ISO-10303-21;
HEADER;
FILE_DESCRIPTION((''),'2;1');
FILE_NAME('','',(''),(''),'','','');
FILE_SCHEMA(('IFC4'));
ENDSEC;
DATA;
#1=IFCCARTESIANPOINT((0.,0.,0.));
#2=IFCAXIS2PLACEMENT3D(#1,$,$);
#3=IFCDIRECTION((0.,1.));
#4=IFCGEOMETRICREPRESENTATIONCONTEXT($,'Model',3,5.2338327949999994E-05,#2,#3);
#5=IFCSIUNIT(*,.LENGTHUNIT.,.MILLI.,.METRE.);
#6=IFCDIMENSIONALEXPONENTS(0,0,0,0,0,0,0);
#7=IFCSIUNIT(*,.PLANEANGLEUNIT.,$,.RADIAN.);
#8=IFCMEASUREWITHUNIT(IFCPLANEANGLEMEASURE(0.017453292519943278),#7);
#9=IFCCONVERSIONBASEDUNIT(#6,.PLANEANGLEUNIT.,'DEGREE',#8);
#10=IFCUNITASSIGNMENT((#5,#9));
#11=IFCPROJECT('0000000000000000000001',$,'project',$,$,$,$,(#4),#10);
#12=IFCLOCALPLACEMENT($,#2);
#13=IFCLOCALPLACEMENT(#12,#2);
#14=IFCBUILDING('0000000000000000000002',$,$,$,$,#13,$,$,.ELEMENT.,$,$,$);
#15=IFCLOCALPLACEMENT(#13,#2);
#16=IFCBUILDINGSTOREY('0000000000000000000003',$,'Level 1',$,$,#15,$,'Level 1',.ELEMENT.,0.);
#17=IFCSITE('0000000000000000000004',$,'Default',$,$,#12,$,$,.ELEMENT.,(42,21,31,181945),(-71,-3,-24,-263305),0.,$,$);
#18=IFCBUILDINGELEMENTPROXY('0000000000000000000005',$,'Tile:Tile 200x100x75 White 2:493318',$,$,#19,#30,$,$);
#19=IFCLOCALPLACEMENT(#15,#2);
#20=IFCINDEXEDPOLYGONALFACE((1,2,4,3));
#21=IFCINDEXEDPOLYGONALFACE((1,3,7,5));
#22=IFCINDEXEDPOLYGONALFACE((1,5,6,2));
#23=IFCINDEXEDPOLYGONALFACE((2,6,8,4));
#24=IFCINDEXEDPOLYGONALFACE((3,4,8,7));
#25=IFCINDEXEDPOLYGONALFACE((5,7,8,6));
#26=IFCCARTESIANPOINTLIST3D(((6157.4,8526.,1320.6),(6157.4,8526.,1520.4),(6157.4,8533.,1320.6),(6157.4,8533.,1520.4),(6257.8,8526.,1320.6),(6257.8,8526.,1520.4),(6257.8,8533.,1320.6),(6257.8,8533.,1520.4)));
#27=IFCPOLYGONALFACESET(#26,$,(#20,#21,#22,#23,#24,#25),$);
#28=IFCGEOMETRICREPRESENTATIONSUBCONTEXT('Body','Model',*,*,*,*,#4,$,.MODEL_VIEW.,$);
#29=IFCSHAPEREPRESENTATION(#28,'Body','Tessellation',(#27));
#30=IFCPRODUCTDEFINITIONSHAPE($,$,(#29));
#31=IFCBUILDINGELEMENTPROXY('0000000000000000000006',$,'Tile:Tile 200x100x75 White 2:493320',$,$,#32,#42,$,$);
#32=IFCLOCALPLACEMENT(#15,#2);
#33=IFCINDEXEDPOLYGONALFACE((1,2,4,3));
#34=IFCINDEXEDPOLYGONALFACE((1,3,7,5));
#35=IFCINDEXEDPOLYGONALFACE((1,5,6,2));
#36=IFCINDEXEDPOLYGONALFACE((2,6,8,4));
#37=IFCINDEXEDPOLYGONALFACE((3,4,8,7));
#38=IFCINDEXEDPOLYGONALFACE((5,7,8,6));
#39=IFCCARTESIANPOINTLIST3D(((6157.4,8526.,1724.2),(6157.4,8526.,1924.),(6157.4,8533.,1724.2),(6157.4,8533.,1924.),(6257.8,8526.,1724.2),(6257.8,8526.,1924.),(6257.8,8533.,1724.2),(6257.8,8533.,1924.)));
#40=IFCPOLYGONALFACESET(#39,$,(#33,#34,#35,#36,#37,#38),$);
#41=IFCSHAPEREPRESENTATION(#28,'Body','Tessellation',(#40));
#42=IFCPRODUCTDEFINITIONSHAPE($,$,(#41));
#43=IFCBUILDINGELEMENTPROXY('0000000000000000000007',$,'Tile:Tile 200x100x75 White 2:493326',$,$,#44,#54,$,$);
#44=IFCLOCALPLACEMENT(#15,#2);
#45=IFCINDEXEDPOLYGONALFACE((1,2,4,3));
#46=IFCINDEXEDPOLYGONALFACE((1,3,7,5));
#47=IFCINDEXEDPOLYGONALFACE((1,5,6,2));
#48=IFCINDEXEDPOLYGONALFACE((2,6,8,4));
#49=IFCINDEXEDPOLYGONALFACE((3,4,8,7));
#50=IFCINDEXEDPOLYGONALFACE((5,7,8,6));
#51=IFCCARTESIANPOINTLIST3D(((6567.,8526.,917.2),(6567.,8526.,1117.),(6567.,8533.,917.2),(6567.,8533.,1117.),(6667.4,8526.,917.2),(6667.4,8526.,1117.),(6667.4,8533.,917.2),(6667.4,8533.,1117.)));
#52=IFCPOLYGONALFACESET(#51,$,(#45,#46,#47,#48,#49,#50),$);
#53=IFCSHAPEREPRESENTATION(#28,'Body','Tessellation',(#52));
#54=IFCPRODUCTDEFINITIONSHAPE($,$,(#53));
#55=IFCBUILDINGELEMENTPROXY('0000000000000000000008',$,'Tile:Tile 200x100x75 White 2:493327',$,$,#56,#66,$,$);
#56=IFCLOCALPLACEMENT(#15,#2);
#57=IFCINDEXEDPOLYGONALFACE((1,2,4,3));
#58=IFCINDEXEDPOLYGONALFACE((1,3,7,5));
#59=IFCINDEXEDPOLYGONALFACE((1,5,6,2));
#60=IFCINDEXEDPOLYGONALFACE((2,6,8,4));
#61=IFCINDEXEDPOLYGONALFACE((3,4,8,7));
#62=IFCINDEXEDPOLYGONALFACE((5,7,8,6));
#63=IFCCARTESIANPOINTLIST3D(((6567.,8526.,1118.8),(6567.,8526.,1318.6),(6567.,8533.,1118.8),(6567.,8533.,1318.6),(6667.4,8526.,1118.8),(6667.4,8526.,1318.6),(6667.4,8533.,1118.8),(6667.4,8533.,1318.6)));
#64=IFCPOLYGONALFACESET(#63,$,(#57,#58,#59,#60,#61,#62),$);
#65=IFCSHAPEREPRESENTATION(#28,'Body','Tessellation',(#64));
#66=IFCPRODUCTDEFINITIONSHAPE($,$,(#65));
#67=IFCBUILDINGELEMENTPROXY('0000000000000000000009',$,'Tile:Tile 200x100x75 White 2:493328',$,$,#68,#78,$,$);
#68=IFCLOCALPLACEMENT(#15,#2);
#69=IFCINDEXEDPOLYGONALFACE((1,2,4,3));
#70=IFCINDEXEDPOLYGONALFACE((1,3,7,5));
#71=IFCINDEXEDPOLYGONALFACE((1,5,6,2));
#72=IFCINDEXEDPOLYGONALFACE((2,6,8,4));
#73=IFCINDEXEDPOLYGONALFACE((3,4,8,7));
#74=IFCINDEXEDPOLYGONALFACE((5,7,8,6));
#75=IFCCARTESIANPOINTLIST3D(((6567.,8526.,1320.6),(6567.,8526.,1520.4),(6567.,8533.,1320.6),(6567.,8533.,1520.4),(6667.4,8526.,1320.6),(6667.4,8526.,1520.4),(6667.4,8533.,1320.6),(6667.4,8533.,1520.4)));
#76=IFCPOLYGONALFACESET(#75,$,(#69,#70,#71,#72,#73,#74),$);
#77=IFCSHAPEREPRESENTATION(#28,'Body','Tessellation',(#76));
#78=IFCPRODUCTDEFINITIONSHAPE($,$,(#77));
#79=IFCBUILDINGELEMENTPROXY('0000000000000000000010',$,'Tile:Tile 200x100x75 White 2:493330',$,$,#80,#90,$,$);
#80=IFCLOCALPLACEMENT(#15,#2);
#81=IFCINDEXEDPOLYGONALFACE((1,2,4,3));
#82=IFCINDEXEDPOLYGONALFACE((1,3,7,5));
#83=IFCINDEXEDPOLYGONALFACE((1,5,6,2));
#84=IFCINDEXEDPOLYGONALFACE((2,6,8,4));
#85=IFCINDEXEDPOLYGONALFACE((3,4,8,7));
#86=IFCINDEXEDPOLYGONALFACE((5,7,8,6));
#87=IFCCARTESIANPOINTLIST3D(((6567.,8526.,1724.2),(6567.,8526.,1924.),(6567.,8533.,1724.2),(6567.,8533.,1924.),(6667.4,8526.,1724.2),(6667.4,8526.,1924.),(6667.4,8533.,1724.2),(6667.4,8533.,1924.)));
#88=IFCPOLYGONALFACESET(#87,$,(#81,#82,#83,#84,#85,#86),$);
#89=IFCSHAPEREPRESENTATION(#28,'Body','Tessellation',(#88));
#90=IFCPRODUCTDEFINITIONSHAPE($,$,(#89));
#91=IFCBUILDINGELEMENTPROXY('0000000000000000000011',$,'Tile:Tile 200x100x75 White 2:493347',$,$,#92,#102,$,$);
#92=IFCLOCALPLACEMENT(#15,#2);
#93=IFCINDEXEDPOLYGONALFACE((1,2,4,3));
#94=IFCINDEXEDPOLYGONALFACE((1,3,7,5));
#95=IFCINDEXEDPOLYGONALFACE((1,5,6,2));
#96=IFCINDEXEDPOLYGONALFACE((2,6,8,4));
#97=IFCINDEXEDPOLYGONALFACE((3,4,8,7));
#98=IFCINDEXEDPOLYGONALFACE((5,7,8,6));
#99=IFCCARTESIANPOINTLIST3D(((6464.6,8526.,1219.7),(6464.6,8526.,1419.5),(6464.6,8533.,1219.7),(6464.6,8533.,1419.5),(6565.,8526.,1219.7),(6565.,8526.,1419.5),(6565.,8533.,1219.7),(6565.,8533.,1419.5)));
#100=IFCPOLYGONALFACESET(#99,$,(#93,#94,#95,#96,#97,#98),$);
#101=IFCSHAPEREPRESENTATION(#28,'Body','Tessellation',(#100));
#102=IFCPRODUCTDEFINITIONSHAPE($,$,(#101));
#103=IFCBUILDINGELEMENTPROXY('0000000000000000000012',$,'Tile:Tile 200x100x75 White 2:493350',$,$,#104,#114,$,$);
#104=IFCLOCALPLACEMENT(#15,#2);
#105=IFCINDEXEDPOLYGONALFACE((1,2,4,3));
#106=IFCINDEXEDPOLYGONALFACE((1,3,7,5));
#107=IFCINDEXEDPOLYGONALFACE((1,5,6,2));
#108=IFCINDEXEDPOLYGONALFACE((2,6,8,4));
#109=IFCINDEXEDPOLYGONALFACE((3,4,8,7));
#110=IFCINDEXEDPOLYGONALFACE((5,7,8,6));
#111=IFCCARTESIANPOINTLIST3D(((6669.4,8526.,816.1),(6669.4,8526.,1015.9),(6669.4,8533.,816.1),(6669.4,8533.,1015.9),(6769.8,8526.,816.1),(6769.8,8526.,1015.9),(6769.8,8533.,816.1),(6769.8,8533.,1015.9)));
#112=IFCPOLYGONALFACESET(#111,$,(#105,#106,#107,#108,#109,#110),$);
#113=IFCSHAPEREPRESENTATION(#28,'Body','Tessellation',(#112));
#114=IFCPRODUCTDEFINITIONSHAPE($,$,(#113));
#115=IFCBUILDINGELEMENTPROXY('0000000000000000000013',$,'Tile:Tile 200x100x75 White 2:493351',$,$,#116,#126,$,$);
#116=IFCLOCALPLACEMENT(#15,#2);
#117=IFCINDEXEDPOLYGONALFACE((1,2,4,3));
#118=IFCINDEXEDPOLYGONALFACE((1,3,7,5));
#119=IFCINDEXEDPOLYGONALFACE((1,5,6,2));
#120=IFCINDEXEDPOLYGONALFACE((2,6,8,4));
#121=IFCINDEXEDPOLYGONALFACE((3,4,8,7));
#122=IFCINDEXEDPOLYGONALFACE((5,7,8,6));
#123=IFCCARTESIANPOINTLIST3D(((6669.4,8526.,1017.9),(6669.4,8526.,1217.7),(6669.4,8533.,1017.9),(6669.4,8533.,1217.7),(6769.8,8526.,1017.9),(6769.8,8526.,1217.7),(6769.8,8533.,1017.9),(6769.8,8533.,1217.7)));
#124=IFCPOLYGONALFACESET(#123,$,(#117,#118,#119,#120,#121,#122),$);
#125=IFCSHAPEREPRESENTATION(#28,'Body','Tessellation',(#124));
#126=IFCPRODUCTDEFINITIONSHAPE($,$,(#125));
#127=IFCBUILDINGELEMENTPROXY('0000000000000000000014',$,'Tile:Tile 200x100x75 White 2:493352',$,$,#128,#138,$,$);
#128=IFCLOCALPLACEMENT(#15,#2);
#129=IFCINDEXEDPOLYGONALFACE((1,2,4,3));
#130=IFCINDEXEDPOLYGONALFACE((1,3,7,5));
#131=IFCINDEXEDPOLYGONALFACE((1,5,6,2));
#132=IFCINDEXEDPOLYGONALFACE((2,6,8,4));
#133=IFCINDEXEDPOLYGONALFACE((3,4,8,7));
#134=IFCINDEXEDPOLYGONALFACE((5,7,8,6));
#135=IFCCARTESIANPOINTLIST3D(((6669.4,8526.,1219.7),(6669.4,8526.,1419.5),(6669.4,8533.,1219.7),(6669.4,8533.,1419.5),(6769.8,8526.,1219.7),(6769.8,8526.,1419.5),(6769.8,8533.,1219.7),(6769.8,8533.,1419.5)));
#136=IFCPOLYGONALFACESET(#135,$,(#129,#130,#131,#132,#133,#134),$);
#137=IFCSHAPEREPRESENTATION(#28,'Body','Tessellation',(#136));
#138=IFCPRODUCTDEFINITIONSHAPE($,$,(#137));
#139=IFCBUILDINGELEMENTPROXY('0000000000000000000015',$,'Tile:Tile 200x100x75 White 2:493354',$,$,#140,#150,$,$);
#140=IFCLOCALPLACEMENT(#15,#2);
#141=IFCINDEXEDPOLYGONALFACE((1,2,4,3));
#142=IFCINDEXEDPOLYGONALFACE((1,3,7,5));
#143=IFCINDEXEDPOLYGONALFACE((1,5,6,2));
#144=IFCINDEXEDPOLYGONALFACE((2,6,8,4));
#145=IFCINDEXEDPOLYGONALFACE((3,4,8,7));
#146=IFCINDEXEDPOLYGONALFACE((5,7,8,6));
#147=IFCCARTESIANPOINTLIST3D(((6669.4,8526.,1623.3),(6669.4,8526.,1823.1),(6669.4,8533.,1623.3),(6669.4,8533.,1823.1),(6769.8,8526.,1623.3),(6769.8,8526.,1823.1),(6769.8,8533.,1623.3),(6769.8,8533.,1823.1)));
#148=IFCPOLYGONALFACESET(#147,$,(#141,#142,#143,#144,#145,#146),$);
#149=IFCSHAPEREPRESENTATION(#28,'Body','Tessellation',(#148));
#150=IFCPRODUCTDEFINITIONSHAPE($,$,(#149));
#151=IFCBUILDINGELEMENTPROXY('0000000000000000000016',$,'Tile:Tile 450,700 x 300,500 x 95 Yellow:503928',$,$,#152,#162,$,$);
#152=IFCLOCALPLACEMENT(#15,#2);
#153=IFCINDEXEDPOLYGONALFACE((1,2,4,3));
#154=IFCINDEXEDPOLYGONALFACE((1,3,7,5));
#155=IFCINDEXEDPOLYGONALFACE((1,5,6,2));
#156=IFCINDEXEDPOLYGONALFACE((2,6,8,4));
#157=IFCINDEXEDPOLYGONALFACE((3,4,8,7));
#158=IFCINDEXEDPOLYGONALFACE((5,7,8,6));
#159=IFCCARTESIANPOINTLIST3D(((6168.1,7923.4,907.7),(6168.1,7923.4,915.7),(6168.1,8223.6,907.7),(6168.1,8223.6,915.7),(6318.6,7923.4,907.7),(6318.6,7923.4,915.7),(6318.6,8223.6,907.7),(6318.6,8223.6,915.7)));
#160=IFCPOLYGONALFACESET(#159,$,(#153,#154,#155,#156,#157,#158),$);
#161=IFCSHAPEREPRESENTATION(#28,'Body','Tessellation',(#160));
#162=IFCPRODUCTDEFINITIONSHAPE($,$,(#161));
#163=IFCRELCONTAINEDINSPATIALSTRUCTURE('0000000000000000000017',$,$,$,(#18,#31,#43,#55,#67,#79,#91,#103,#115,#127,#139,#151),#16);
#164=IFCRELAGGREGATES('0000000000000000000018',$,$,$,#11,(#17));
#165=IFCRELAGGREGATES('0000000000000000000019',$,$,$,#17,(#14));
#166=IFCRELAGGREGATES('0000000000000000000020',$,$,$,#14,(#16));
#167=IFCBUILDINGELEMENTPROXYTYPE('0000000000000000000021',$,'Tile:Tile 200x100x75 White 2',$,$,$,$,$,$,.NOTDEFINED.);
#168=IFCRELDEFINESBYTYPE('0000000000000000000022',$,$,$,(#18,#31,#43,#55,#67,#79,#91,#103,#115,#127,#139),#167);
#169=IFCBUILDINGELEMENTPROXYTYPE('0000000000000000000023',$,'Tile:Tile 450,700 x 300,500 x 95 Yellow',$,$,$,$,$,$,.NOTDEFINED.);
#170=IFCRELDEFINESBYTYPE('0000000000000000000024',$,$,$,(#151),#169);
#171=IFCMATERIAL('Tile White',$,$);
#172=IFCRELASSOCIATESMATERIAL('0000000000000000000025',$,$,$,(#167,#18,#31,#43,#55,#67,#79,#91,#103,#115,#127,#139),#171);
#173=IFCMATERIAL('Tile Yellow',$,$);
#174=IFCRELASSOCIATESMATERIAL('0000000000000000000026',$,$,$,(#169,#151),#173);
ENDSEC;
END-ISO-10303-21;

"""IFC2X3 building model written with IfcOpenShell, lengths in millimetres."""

from ifc_helpers import new_model, entity, si_unit, converted_unit, direction, frame, frame_2d, origin, place, context, subcontext, project, spatial, rectangle, extrude, source, transform, mapped, material, type_object, type_shapes, element, save


model = new_model("IFC2X3")

# Units and contexts
model_context = context("Model", 3, precision=5.2338327949999994e-05, world=origin(), true_north=direction((0.0, 1.0)))
body_context = subcontext(model_context, "Body", "Model", "MODEL_VIEW")
ifc_project = project(units=[si_unit("LENGTHUNIT", "METRE", prefix="MILLI"), converted_unit("PLANEANGLEUNIT", "DEGREE", entity("IfcPlaneAngleMeasure", 0.017453292519943278), si_unit("PLANEANGLEUNIT", "RADIAN"), dimensions=[0, 0, 0, 0, 0, 0, 0])], contexts=[model_context])

# Site, building, storey
site_placement = place(None, origin())
site = spatial("IfcSite", under=ifc_project, at=site_placement, Name="Default", CompositionType="ELEMENT", RefLatitude=(42, 21, 31, 181945), RefLongitude=(-71, -3, -24, -263305), RefElevation=0.0)
building_placement = place(site_placement, origin())
building = spatial("IfcBuilding", under=site, at=building_placement, CompositionType="ELEMENT")
storey_placement = place(building_placement, origin())
storey = spatial("IfcBuildingStorey", under=building, at=storey_placement, Name="Level 1", LongName="Level 1", CompositionType="ELEMENT", Elevation=0.0)

# Building element proxies
ifc_material_1 = material(Name="Tile White")
ifc_material_2 = material(Name="Tile Yellow")
building_element_proxy_type_1 = type_object("IfcBuildingElementProxyType", Name="Tile:Tile 200x100x75 White 2", PredefinedType="NOTDEFINED", material=ifc_material_1)
shared_shape_1 = source(origin(), body_context, "Body", "SweptSolid", [
    extrude(rectangle(XDim=199.8, YDim=100.4, at=frame_2d((0.0, 0.0), x_axis=(1.0, 0.0))), frame((-50.2, -99.9, 0.0), z_axis=(0.0, 0.0, 1.0), x_axis=(0.0, -1.0, 0.0)), (0.0, 0.0, 1.0), 7.0),
])
type_shapes(building_element_proxy_type_1, [shared_shape_1])
for number, where, z_axis, x_axis, name in (
    (1, (6257.8, 8533.0, 1520.4), (0.0, -1.0, 0.0), (1.0, 0.0, 0.0), "Tile:Tile 200x100x75 White 2:493318"),
    (2, (6257.8, 8533.0, 1924.0), (0.0, -1.0, 0.0), (1.0, 0.0, 0.0), "Tile:Tile 200x100x75 White 2:493320"),
    (3, (6667.4, 8533.0, 1117.0), (0.0, -1.0, 0.0), (1.0, 0.0, 0.0), "Tile:Tile 200x100x75 White 2:493326"),
    (4, (6667.4, 8533.0, 1318.6), (0.0, -1.0, 0.0), (1.0, 0.0, 0.0), "Tile:Tile 200x100x75 White 2:493327"),
    (5, (6667.4, 8533.0, 1520.4), (0.0, -1.0, 0.0), (1.0, 0.0, 0.0), "Tile:Tile 200x100x75 White 2:493328"),
    (6, (6667.4, 8533.0, 1924.0), (0.0, -1.0, 0.0), (1.0, 0.0, 0.0), "Tile:Tile 200x100x75 White 2:493330"),
    (7, (6565.0, 8533.0, 1419.5), (0.0, -1.0, 0.0), (1.0, 0.0, 0.0), "Tile:Tile 200x100x75 White 2:493347"),
    (8, (6769.8, 8533.0, 1015.9), (0.0, -1.0, 0.0), (1.0, 0.0, 0.0), "Tile:Tile 200x100x75 White 2:493350"),
    (9, (6769.8, 8533.0, 1217.7), (0.0, -1.0, 0.0), (1.0, 0.0, 0.0), "Tile:Tile 200x100x75 White 2:493351"),
    (10, (6769.8, 8533.0, 1419.5), (0.0, -1.0, 0.0), (1.0, 0.0, 0.0), "Tile:Tile 200x100x75 White 2:493352"),
    (11, (6769.8, 8533.0, 1823.1), (0.0, -1.0, 0.0), (1.0, 0.0, 0.0), "Tile:Tile 200x100x75 White 2:493354"),
):
    element("IfcBuildingElementProxy", number, at=place(storey_placement, frame(where, z_axis=z_axis, x_axis=x_axis)), inside=storey, type_object=building_element_proxy_type_1, material=ifc_material_1, Name=name, context=body_context, shape_type="MappedRepresentation", body=[
        mapped(shared_shape_1, transform((0.0, 0.0, 0.0), scale=1.0)),
    ])
building_element_proxy_type_2 = type_object("IfcBuildingElementProxyType", Name="Tile:Tile 450,700 x 300,500 x 95 Yellow", PredefinedType="NOTDEFINED", material=ifc_material_2)
shared_shape_2 = source(origin(), body_context, "Body", "SweptSolid", [
    extrude(rectangle(XDim=150.5, YDim=300.2, at=frame_2d((0.0, 0.0), x_axis=(1.0, 0.0))), frame((-75.2, -150.1, 0.0), z_axis=(0.0, 0.0, 1.0), x_axis=(-1.0, 0.0, 0.0)), (0.0, 0.0, 1.0), 8.0),
])
type_shapes(building_element_proxy_type_2, [shared_shape_2])
proxy_1_placement = place(storey_placement, frame((6318.6, 8223.6, 907.7)))
element("IfcBuildingElementProxy", 12, at=proxy_1_placement, inside=storey, type_object=building_element_proxy_type_2, material=ifc_material_2, Name="Tile:Tile 450,700 x 300,500 x 95 Yellow:503928", context=body_context, shape_type="MappedRepresentation", body=[
    mapped(shared_shape_2, transform((0.0, 0.0, 0.0), scale=1.0)),
])

save(model, "model.ifc")
